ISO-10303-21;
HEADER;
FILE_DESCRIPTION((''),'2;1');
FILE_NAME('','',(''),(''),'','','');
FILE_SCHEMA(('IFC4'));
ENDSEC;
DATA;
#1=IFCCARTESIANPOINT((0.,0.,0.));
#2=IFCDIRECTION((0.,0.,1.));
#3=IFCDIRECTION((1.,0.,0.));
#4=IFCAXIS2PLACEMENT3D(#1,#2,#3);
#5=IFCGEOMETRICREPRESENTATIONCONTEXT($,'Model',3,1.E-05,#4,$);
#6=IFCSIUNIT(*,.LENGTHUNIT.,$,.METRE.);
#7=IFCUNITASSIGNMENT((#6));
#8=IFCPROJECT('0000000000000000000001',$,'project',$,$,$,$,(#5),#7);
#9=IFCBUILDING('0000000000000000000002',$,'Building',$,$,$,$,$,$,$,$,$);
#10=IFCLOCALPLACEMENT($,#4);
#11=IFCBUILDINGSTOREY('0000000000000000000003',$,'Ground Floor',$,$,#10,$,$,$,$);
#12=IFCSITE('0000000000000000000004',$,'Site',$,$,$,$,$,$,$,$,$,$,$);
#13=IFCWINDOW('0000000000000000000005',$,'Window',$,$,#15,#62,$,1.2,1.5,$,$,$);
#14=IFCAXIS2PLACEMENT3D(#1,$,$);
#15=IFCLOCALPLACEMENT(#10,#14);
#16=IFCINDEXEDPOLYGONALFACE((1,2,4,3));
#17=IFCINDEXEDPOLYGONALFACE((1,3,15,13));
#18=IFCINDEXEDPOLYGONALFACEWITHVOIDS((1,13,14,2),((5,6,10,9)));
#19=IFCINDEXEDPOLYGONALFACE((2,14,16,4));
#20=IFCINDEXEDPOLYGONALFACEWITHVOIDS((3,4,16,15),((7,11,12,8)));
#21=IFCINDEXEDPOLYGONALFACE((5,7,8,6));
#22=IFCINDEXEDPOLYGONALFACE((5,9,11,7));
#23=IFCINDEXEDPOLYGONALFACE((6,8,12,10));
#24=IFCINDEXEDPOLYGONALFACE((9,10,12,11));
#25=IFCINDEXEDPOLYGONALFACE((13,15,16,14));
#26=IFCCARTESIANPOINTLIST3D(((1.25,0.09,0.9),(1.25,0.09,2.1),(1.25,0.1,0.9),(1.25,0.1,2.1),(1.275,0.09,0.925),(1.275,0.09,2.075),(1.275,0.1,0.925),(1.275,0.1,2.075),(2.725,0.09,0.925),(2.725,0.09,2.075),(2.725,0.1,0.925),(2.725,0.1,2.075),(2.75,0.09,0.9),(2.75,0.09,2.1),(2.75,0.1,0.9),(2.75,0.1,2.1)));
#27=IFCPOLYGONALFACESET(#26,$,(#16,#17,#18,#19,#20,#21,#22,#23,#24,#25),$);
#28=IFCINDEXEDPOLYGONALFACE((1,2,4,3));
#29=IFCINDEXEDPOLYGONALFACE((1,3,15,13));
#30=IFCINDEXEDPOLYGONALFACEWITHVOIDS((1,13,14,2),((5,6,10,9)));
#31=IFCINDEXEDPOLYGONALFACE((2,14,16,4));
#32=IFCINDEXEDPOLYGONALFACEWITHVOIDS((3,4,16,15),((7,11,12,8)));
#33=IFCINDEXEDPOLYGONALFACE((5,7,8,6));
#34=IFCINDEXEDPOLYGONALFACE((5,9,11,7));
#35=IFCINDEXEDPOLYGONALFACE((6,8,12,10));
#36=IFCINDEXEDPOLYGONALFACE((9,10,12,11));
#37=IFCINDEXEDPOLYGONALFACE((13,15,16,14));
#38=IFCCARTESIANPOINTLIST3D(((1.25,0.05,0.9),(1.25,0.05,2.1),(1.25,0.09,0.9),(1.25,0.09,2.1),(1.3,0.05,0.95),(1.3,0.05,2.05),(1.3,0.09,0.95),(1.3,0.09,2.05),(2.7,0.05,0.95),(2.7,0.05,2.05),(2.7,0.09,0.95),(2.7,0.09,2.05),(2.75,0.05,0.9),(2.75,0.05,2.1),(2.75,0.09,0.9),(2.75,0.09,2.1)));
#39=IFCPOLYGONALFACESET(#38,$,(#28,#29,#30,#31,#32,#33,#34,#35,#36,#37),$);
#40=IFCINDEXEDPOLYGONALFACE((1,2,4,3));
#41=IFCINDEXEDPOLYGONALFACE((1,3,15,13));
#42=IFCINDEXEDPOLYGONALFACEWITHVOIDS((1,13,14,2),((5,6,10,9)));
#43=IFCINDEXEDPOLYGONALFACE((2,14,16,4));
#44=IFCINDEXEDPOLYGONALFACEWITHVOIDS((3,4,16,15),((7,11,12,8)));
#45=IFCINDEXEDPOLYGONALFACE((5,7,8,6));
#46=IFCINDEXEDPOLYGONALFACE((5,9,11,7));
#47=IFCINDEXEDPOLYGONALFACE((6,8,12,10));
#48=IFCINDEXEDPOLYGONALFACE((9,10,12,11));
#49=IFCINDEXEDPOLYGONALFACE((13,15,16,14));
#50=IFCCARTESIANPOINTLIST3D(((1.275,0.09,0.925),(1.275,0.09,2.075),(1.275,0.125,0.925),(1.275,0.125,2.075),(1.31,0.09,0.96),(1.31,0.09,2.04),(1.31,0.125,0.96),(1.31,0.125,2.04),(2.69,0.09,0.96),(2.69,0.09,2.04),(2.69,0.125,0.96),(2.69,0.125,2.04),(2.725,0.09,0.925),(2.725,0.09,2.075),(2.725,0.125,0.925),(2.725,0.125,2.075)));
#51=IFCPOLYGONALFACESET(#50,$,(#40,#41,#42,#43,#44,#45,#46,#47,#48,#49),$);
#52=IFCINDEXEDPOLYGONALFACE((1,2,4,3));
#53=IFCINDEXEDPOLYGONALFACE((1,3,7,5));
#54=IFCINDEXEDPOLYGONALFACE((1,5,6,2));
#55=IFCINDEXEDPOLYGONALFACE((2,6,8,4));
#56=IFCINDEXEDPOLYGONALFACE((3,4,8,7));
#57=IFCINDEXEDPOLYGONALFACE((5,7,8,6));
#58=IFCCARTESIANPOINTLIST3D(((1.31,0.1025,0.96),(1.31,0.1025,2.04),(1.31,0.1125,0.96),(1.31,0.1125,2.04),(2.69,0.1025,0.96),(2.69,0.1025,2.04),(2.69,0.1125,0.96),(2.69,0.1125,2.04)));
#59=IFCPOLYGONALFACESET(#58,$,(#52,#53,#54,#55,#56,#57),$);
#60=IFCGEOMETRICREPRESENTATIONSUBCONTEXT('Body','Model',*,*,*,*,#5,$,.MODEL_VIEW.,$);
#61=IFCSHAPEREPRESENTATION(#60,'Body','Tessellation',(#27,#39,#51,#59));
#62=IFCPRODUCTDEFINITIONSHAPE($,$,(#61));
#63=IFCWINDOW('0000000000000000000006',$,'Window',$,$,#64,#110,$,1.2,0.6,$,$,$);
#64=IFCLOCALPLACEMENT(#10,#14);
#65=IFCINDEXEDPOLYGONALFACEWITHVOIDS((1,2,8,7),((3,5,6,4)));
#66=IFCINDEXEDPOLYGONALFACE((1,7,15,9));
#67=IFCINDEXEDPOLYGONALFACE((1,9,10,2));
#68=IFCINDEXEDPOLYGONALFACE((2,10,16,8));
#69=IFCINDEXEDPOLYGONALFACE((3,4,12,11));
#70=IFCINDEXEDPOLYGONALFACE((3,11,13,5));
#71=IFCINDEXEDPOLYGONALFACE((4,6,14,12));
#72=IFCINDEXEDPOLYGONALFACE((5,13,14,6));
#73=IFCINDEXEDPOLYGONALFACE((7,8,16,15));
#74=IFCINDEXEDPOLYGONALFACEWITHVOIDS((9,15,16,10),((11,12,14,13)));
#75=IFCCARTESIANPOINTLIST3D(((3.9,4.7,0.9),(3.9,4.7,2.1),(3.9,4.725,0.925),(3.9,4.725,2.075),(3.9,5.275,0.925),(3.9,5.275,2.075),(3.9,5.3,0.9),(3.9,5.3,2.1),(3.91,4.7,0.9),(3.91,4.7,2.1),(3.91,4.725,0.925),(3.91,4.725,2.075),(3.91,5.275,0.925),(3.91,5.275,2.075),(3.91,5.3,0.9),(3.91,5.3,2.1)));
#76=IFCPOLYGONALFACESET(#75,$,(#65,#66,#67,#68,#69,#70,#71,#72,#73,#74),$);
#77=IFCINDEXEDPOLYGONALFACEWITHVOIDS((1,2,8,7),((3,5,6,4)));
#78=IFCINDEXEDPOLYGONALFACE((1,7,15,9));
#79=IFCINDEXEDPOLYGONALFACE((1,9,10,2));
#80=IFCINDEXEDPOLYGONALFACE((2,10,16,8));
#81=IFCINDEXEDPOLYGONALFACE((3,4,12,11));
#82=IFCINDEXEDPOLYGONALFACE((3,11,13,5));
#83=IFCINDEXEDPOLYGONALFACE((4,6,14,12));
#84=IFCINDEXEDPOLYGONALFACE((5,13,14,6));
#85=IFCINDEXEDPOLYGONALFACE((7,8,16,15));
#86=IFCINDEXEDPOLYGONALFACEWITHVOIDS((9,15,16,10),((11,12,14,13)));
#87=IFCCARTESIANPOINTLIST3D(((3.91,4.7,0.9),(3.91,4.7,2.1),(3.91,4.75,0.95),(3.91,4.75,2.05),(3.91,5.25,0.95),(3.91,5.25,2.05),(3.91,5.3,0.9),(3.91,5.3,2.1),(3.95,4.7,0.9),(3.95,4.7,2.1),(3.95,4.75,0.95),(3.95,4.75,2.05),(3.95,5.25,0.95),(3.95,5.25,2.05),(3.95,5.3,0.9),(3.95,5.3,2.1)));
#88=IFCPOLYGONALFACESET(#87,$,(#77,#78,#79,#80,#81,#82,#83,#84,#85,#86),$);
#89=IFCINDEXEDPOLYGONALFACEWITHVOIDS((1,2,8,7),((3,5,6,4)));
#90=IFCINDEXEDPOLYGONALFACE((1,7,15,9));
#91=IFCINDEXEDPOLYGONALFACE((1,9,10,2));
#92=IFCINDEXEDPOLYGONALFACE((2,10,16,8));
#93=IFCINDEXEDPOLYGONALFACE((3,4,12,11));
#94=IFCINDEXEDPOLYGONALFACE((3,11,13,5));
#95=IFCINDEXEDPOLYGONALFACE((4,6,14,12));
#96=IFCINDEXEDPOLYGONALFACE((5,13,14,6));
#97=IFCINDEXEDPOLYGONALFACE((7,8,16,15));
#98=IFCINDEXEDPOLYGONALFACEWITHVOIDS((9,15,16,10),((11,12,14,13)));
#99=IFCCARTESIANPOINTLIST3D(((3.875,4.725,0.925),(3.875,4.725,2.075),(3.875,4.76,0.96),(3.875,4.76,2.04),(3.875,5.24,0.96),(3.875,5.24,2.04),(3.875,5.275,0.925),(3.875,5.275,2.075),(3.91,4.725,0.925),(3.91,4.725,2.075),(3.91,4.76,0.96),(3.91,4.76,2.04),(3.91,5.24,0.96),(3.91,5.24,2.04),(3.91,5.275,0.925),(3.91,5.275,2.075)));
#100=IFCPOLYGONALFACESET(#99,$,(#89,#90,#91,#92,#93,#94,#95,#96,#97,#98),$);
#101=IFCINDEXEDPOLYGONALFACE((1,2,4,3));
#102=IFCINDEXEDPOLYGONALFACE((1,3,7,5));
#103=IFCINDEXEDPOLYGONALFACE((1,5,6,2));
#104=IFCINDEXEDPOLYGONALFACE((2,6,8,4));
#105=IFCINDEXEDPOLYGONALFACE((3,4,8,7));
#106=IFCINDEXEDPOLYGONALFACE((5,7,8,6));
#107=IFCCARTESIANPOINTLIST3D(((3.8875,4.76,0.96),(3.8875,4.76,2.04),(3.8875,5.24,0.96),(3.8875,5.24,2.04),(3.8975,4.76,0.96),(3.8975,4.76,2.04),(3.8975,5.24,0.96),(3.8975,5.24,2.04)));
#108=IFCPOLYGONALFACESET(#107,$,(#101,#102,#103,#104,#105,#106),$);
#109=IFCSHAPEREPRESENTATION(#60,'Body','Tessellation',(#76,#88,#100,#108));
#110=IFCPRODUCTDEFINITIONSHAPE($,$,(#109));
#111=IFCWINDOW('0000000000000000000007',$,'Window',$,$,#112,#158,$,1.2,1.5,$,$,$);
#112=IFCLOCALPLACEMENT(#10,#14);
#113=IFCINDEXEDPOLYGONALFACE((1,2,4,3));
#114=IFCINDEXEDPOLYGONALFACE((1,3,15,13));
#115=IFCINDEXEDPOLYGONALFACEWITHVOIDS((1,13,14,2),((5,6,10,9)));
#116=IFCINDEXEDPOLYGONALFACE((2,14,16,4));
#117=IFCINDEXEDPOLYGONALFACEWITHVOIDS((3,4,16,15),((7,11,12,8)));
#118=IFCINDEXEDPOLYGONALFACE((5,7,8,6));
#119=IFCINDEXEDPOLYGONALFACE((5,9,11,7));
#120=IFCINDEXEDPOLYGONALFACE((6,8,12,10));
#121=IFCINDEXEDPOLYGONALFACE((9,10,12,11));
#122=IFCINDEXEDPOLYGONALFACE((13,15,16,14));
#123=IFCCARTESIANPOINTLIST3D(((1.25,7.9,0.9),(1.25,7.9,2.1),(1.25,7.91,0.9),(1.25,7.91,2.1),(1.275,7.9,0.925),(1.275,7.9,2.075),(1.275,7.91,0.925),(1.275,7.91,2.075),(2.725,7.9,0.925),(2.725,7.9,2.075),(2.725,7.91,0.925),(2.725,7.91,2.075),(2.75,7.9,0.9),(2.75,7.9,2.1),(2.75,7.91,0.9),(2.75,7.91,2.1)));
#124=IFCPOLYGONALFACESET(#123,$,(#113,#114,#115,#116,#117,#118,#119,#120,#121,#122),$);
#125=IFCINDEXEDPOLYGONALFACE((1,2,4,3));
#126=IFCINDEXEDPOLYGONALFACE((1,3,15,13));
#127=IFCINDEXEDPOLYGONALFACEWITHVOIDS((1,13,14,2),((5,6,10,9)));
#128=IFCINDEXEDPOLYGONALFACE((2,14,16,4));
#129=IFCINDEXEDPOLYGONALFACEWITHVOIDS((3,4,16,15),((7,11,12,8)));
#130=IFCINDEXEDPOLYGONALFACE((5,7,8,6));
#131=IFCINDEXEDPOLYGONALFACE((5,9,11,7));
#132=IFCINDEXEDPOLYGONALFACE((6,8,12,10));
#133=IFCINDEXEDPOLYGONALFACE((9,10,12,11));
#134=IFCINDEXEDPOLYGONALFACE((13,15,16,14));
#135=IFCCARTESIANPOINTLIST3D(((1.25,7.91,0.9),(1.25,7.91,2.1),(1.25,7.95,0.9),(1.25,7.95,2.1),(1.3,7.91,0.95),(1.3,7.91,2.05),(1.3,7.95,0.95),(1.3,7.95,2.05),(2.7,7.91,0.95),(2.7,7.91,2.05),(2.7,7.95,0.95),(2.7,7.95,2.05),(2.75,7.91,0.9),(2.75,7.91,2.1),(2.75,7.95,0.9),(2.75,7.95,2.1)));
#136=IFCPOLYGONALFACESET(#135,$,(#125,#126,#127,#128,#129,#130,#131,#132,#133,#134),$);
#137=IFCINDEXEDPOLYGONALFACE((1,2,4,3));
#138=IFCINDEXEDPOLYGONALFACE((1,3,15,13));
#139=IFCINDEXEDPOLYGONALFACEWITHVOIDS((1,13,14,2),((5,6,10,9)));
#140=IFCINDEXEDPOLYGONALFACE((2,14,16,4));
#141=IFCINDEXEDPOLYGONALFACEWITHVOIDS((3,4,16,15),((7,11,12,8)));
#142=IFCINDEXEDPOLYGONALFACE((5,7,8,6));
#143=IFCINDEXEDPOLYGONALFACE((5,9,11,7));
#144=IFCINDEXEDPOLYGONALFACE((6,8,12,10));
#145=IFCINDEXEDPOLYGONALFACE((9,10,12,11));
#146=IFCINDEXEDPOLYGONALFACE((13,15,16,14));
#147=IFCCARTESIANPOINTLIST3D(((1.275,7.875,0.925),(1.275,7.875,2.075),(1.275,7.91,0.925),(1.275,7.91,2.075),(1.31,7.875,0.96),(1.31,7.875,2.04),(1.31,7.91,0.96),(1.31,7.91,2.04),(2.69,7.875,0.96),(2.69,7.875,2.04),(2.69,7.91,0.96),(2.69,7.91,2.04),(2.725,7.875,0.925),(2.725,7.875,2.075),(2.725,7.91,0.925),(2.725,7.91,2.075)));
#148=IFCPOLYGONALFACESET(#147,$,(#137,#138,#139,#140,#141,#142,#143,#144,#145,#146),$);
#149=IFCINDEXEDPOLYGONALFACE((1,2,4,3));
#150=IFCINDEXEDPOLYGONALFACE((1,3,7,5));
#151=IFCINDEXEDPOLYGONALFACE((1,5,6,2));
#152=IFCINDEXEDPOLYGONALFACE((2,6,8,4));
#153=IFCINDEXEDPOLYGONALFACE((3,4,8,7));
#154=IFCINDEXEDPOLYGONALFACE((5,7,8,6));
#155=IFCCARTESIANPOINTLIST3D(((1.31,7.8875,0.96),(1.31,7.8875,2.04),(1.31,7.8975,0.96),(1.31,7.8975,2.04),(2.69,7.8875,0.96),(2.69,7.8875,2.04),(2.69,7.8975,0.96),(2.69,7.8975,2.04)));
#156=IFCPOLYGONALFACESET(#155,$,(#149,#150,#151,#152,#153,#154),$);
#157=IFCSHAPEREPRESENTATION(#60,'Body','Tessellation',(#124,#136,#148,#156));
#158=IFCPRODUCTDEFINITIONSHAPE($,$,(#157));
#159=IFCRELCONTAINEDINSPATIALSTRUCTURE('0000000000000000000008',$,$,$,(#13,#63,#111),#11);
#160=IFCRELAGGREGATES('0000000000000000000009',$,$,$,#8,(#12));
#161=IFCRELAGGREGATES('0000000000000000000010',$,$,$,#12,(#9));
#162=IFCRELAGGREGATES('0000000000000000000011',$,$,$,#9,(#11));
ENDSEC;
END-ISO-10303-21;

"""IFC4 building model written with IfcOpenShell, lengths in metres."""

from ifc_helpers import new_model, si_unit, frame, origin_with_axes, place, context, subcontext, project, spatial, line, indexed_curve, outline, extrude, element, save


model = new_model("IFC4")

# Units and contexts
model_context = context("Model", 3, precision=1e-05, world=origin_with_axes())
body_context = subcontext(model_context, "Body", "Model", "MODEL_VIEW")
ifc_project = project(units=[si_unit("LENGTHUNIT", "METRE")], contexts=[model_context])

# Site, building, storey
site = spatial("IfcSite", under=ifc_project, Name="Site")
building = spatial("IfcBuilding", under=site, Name="Building")
storey_placement = place(None, origin_with_axes())
storey = spatial("IfcBuildingStorey", under=building, at=storey_placement, Name="Ground Floor")

# Windows
window_1_placement = place(storey_placement, frame((1.25, 0.0, 0.9), z_axis=(0.0, 0.0, 1.0), x_axis=(1.0, 0.0, 0.0)))
element("IfcWindow", 1, at=window_1_placement, inside=storey, Name="Window", OverallHeight=1.2, OverallWidth=1.5, context=body_context, shape_type="SweptSolid", body=[
    extrude(outline(indexed_curve([(0.0, 0.0), (1.5, 0.0), (1.5, 1.2), (0.0, 1.2)], segments=[line(1, 2, 3, 4, 1)]), holes=[indexed_curve([(0.025, 0.025), (1.475, 0.025), (1.475, 1.175), (0.025, 1.175)], segments=[line(1, 2, 3, 4, 1)])]), frame((0.0, 0.09, 0.0), z_axis=(0.0, -1.0, 0.0), x_axis=(1.0, 0.0, 0.0)), (0.0, 0.0, -1.0), 0.01),
    extrude(outline(indexed_curve([(0.0, 0.0), (1.5, 0.0), (1.5, 1.2), (0.0, 1.2)], segments=[line(1, 2, 3, 4, 1)]), holes=[indexed_curve([(0.05, 0.05), (1.45, 0.05), (1.45, 1.15), (0.05, 1.15)], segments=[line(1, 2, 3, 4, 1)])]), frame((0.0, 0.05, 0.0), z_axis=(0.0, -1.0, 0.0), x_axis=(1.0, 0.0, 0.0)), (0.0, 0.0, -1.0), 0.04),
    extrude(outline(indexed_curve([(0.0, 0.0), (1.45, 0.0), (1.45, 1.15), (0.0, 1.15)], segments=[line(1, 2, 3, 4, 1)]), holes=[indexed_curve([(0.035, 0.035), (1.415, 0.035), (1.415, 1.115), (0.035, 1.115)], segments=[line(1, 2, 3, 4, 1)])]), frame((0.025, 0.09, 0.025), z_axis=(0.0, -1.0, 0.0), x_axis=(1.0, 0.0, 0.0)), (0.0, 0.0, -1.0), 0.035),
    extrude(outline(indexed_curve([(0.035, 0.035), (1.415, 0.035), (1.415, 1.115), (0.035, 1.115)], segments=[line(1, 2, 3, 4, 1)])), frame((0.025, 0.1025, 0.025), z_axis=(0.0, -1.0, 0.0), x_axis=(1.0, 0.0, 0.0)), (0.0, 0.0, -1.0), 0.01),
])
window_2_placement = place(storey_placement, frame((4.0, 4.7, 0.9), z_axis=(0.0, 0.0, 1.0), x_axis=(0.0, 1.0, 0.0)))
element("IfcWindow", 2, at=window_2_placement, inside=storey, Name="Window", OverallHeight=1.2, OverallWidth=0.6, context=body_context, shape_type="SweptSolid", body=[
    extrude(outline(indexed_curve([(0.0, 0.0), (0.6, 0.0), (0.6, 1.2), (0.0, 1.2)], segments=[line(1, 2, 3, 4, 1)]), holes=[indexed_curve([(0.025, 0.025), (0.575, 0.025), (0.575, 1.175), (0.025, 1.175)], segments=[line(1, 2, 3, 4, 1)])]), frame((0.0, 0.09, 0.0), z_axis=(0.0, -1.0, 0.0), x_axis=(1.0, 0.0, 0.0)), (0.0, 0.0, -1.0), 0.01),
    extrude(outline(indexed_curve([(0.0, 0.0), (0.6, 0.0), (0.6, 1.2), (0.0, 1.2)], segments=[line(1, 2, 3, 4, 1)]), holes=[indexed_curve([(0.05, 0.05), (0.55, 0.05), (0.55, 1.15), (0.05, 1.15)], segments=[line(1, 2, 3, 4, 1)])]), frame((0.0, 0.05, 0.0), z_axis=(0.0, -1.0, 0.0), x_axis=(1.0, 0.0, 0.0)), (0.0, 0.0, -1.0), 0.04),
    extrude(outline(indexed_curve([(0.0, 0.0), (0.55, 0.0), (0.55, 1.15), (0.0, 1.15)], segments=[line(1, 2, 3, 4, 1)]), holes=[indexed_curve([(0.035, 0.035), (0.515, 0.035), (0.515, 1.115), (0.035, 1.115)], segments=[line(1, 2, 3, 4, 1)])]), frame((0.025, 0.09, 0.025), z_axis=(0.0, -1.0, 0.0), x_axis=(1.0, 0.0, 0.0)), (0.0, 0.0, -1.0), 0.035),
    extrude(outline(indexed_curve([(0.035, 0.035), (0.515, 0.035), (0.515, 1.115), (0.035, 1.115)], segments=[line(1, 2, 3, 4, 1)])), frame((0.025, 0.1025, 0.025), z_axis=(0.0, -1.0, 0.0), x_axis=(1.0, 0.0, 0.0)), (0.0, 0.0, -1.0), 0.01),
])
window_3_placement = place(storey_placement, frame((2.75, 8.0, 0.9), z_axis=(0.0, 0.0, 1.0), x_axis=(-1.0, 0.0, 0.0)))
element("IfcWindow", 3, at=window_3_placement, inside=storey, Name="Window", OverallHeight=1.2, OverallWidth=1.5, context=body_context, shape_type="SweptSolid", body=[
    extrude(outline(indexed_curve([(0.0, 0.0), (1.5, 0.0), (1.5, 1.2), (0.0, 1.2)], segments=[line(1, 2, 3, 4, 1)]), holes=[indexed_curve([(0.025, 0.025), (1.475, 0.025), (1.475, 1.175), (0.025, 1.175)], segments=[line(1, 2, 3, 4, 1)])]), frame((0.0, 0.09, 0.0), z_axis=(0.0, -1.0, 0.0), x_axis=(1.0, 0.0, 0.0)), (0.0, 0.0, -1.0), 0.01),
    extrude(outline(indexed_curve([(0.0, 0.0), (1.5, 0.0), (1.5, 1.2), (0.0, 1.2)], segments=[line(1, 2, 3, 4, 1)]), holes=[indexed_curve([(0.05, 0.05), (1.45, 0.05), (1.45, 1.15), (0.05, 1.15)], segments=[line(1, 2, 3, 4, 1)])]), frame((0.0, 0.05, 0.0), z_axis=(0.0, -1.0, 0.0), x_axis=(1.0, 0.0, 0.0)), (0.0, 0.0, -1.0), 0.04),
    extrude(outline(indexed_curve([(0.0, 0.0), (1.45, 0.0), (1.45, 1.15), (0.0, 1.15)], segments=[line(1, 2, 3, 4, 1)]), holes=[indexed_curve([(0.035, 0.035), (1.415, 0.035), (1.415, 1.115), (0.035, 1.115)], segments=[line(1, 2, 3, 4, 1)])]), frame((0.025, 0.09, 0.025), z_axis=(0.0, -1.0, 0.0), x_axis=(1.0, 0.0, 0.0)), (0.0, 0.0, -1.0), 0.035),
    extrude(outline(indexed_curve([(0.035, 0.035), (1.415, 0.035), (1.415, 1.115), (0.035, 1.115)], segments=[line(1, 2, 3, 4, 1)])), frame((0.025, 0.1025, 0.025), z_axis=(0.0, -1.0, 0.0), x_axis=(1.0, 0.0, 0.0)), (0.0, 0.0, -1.0), 0.01),
])

save(model, "model.ifc")
